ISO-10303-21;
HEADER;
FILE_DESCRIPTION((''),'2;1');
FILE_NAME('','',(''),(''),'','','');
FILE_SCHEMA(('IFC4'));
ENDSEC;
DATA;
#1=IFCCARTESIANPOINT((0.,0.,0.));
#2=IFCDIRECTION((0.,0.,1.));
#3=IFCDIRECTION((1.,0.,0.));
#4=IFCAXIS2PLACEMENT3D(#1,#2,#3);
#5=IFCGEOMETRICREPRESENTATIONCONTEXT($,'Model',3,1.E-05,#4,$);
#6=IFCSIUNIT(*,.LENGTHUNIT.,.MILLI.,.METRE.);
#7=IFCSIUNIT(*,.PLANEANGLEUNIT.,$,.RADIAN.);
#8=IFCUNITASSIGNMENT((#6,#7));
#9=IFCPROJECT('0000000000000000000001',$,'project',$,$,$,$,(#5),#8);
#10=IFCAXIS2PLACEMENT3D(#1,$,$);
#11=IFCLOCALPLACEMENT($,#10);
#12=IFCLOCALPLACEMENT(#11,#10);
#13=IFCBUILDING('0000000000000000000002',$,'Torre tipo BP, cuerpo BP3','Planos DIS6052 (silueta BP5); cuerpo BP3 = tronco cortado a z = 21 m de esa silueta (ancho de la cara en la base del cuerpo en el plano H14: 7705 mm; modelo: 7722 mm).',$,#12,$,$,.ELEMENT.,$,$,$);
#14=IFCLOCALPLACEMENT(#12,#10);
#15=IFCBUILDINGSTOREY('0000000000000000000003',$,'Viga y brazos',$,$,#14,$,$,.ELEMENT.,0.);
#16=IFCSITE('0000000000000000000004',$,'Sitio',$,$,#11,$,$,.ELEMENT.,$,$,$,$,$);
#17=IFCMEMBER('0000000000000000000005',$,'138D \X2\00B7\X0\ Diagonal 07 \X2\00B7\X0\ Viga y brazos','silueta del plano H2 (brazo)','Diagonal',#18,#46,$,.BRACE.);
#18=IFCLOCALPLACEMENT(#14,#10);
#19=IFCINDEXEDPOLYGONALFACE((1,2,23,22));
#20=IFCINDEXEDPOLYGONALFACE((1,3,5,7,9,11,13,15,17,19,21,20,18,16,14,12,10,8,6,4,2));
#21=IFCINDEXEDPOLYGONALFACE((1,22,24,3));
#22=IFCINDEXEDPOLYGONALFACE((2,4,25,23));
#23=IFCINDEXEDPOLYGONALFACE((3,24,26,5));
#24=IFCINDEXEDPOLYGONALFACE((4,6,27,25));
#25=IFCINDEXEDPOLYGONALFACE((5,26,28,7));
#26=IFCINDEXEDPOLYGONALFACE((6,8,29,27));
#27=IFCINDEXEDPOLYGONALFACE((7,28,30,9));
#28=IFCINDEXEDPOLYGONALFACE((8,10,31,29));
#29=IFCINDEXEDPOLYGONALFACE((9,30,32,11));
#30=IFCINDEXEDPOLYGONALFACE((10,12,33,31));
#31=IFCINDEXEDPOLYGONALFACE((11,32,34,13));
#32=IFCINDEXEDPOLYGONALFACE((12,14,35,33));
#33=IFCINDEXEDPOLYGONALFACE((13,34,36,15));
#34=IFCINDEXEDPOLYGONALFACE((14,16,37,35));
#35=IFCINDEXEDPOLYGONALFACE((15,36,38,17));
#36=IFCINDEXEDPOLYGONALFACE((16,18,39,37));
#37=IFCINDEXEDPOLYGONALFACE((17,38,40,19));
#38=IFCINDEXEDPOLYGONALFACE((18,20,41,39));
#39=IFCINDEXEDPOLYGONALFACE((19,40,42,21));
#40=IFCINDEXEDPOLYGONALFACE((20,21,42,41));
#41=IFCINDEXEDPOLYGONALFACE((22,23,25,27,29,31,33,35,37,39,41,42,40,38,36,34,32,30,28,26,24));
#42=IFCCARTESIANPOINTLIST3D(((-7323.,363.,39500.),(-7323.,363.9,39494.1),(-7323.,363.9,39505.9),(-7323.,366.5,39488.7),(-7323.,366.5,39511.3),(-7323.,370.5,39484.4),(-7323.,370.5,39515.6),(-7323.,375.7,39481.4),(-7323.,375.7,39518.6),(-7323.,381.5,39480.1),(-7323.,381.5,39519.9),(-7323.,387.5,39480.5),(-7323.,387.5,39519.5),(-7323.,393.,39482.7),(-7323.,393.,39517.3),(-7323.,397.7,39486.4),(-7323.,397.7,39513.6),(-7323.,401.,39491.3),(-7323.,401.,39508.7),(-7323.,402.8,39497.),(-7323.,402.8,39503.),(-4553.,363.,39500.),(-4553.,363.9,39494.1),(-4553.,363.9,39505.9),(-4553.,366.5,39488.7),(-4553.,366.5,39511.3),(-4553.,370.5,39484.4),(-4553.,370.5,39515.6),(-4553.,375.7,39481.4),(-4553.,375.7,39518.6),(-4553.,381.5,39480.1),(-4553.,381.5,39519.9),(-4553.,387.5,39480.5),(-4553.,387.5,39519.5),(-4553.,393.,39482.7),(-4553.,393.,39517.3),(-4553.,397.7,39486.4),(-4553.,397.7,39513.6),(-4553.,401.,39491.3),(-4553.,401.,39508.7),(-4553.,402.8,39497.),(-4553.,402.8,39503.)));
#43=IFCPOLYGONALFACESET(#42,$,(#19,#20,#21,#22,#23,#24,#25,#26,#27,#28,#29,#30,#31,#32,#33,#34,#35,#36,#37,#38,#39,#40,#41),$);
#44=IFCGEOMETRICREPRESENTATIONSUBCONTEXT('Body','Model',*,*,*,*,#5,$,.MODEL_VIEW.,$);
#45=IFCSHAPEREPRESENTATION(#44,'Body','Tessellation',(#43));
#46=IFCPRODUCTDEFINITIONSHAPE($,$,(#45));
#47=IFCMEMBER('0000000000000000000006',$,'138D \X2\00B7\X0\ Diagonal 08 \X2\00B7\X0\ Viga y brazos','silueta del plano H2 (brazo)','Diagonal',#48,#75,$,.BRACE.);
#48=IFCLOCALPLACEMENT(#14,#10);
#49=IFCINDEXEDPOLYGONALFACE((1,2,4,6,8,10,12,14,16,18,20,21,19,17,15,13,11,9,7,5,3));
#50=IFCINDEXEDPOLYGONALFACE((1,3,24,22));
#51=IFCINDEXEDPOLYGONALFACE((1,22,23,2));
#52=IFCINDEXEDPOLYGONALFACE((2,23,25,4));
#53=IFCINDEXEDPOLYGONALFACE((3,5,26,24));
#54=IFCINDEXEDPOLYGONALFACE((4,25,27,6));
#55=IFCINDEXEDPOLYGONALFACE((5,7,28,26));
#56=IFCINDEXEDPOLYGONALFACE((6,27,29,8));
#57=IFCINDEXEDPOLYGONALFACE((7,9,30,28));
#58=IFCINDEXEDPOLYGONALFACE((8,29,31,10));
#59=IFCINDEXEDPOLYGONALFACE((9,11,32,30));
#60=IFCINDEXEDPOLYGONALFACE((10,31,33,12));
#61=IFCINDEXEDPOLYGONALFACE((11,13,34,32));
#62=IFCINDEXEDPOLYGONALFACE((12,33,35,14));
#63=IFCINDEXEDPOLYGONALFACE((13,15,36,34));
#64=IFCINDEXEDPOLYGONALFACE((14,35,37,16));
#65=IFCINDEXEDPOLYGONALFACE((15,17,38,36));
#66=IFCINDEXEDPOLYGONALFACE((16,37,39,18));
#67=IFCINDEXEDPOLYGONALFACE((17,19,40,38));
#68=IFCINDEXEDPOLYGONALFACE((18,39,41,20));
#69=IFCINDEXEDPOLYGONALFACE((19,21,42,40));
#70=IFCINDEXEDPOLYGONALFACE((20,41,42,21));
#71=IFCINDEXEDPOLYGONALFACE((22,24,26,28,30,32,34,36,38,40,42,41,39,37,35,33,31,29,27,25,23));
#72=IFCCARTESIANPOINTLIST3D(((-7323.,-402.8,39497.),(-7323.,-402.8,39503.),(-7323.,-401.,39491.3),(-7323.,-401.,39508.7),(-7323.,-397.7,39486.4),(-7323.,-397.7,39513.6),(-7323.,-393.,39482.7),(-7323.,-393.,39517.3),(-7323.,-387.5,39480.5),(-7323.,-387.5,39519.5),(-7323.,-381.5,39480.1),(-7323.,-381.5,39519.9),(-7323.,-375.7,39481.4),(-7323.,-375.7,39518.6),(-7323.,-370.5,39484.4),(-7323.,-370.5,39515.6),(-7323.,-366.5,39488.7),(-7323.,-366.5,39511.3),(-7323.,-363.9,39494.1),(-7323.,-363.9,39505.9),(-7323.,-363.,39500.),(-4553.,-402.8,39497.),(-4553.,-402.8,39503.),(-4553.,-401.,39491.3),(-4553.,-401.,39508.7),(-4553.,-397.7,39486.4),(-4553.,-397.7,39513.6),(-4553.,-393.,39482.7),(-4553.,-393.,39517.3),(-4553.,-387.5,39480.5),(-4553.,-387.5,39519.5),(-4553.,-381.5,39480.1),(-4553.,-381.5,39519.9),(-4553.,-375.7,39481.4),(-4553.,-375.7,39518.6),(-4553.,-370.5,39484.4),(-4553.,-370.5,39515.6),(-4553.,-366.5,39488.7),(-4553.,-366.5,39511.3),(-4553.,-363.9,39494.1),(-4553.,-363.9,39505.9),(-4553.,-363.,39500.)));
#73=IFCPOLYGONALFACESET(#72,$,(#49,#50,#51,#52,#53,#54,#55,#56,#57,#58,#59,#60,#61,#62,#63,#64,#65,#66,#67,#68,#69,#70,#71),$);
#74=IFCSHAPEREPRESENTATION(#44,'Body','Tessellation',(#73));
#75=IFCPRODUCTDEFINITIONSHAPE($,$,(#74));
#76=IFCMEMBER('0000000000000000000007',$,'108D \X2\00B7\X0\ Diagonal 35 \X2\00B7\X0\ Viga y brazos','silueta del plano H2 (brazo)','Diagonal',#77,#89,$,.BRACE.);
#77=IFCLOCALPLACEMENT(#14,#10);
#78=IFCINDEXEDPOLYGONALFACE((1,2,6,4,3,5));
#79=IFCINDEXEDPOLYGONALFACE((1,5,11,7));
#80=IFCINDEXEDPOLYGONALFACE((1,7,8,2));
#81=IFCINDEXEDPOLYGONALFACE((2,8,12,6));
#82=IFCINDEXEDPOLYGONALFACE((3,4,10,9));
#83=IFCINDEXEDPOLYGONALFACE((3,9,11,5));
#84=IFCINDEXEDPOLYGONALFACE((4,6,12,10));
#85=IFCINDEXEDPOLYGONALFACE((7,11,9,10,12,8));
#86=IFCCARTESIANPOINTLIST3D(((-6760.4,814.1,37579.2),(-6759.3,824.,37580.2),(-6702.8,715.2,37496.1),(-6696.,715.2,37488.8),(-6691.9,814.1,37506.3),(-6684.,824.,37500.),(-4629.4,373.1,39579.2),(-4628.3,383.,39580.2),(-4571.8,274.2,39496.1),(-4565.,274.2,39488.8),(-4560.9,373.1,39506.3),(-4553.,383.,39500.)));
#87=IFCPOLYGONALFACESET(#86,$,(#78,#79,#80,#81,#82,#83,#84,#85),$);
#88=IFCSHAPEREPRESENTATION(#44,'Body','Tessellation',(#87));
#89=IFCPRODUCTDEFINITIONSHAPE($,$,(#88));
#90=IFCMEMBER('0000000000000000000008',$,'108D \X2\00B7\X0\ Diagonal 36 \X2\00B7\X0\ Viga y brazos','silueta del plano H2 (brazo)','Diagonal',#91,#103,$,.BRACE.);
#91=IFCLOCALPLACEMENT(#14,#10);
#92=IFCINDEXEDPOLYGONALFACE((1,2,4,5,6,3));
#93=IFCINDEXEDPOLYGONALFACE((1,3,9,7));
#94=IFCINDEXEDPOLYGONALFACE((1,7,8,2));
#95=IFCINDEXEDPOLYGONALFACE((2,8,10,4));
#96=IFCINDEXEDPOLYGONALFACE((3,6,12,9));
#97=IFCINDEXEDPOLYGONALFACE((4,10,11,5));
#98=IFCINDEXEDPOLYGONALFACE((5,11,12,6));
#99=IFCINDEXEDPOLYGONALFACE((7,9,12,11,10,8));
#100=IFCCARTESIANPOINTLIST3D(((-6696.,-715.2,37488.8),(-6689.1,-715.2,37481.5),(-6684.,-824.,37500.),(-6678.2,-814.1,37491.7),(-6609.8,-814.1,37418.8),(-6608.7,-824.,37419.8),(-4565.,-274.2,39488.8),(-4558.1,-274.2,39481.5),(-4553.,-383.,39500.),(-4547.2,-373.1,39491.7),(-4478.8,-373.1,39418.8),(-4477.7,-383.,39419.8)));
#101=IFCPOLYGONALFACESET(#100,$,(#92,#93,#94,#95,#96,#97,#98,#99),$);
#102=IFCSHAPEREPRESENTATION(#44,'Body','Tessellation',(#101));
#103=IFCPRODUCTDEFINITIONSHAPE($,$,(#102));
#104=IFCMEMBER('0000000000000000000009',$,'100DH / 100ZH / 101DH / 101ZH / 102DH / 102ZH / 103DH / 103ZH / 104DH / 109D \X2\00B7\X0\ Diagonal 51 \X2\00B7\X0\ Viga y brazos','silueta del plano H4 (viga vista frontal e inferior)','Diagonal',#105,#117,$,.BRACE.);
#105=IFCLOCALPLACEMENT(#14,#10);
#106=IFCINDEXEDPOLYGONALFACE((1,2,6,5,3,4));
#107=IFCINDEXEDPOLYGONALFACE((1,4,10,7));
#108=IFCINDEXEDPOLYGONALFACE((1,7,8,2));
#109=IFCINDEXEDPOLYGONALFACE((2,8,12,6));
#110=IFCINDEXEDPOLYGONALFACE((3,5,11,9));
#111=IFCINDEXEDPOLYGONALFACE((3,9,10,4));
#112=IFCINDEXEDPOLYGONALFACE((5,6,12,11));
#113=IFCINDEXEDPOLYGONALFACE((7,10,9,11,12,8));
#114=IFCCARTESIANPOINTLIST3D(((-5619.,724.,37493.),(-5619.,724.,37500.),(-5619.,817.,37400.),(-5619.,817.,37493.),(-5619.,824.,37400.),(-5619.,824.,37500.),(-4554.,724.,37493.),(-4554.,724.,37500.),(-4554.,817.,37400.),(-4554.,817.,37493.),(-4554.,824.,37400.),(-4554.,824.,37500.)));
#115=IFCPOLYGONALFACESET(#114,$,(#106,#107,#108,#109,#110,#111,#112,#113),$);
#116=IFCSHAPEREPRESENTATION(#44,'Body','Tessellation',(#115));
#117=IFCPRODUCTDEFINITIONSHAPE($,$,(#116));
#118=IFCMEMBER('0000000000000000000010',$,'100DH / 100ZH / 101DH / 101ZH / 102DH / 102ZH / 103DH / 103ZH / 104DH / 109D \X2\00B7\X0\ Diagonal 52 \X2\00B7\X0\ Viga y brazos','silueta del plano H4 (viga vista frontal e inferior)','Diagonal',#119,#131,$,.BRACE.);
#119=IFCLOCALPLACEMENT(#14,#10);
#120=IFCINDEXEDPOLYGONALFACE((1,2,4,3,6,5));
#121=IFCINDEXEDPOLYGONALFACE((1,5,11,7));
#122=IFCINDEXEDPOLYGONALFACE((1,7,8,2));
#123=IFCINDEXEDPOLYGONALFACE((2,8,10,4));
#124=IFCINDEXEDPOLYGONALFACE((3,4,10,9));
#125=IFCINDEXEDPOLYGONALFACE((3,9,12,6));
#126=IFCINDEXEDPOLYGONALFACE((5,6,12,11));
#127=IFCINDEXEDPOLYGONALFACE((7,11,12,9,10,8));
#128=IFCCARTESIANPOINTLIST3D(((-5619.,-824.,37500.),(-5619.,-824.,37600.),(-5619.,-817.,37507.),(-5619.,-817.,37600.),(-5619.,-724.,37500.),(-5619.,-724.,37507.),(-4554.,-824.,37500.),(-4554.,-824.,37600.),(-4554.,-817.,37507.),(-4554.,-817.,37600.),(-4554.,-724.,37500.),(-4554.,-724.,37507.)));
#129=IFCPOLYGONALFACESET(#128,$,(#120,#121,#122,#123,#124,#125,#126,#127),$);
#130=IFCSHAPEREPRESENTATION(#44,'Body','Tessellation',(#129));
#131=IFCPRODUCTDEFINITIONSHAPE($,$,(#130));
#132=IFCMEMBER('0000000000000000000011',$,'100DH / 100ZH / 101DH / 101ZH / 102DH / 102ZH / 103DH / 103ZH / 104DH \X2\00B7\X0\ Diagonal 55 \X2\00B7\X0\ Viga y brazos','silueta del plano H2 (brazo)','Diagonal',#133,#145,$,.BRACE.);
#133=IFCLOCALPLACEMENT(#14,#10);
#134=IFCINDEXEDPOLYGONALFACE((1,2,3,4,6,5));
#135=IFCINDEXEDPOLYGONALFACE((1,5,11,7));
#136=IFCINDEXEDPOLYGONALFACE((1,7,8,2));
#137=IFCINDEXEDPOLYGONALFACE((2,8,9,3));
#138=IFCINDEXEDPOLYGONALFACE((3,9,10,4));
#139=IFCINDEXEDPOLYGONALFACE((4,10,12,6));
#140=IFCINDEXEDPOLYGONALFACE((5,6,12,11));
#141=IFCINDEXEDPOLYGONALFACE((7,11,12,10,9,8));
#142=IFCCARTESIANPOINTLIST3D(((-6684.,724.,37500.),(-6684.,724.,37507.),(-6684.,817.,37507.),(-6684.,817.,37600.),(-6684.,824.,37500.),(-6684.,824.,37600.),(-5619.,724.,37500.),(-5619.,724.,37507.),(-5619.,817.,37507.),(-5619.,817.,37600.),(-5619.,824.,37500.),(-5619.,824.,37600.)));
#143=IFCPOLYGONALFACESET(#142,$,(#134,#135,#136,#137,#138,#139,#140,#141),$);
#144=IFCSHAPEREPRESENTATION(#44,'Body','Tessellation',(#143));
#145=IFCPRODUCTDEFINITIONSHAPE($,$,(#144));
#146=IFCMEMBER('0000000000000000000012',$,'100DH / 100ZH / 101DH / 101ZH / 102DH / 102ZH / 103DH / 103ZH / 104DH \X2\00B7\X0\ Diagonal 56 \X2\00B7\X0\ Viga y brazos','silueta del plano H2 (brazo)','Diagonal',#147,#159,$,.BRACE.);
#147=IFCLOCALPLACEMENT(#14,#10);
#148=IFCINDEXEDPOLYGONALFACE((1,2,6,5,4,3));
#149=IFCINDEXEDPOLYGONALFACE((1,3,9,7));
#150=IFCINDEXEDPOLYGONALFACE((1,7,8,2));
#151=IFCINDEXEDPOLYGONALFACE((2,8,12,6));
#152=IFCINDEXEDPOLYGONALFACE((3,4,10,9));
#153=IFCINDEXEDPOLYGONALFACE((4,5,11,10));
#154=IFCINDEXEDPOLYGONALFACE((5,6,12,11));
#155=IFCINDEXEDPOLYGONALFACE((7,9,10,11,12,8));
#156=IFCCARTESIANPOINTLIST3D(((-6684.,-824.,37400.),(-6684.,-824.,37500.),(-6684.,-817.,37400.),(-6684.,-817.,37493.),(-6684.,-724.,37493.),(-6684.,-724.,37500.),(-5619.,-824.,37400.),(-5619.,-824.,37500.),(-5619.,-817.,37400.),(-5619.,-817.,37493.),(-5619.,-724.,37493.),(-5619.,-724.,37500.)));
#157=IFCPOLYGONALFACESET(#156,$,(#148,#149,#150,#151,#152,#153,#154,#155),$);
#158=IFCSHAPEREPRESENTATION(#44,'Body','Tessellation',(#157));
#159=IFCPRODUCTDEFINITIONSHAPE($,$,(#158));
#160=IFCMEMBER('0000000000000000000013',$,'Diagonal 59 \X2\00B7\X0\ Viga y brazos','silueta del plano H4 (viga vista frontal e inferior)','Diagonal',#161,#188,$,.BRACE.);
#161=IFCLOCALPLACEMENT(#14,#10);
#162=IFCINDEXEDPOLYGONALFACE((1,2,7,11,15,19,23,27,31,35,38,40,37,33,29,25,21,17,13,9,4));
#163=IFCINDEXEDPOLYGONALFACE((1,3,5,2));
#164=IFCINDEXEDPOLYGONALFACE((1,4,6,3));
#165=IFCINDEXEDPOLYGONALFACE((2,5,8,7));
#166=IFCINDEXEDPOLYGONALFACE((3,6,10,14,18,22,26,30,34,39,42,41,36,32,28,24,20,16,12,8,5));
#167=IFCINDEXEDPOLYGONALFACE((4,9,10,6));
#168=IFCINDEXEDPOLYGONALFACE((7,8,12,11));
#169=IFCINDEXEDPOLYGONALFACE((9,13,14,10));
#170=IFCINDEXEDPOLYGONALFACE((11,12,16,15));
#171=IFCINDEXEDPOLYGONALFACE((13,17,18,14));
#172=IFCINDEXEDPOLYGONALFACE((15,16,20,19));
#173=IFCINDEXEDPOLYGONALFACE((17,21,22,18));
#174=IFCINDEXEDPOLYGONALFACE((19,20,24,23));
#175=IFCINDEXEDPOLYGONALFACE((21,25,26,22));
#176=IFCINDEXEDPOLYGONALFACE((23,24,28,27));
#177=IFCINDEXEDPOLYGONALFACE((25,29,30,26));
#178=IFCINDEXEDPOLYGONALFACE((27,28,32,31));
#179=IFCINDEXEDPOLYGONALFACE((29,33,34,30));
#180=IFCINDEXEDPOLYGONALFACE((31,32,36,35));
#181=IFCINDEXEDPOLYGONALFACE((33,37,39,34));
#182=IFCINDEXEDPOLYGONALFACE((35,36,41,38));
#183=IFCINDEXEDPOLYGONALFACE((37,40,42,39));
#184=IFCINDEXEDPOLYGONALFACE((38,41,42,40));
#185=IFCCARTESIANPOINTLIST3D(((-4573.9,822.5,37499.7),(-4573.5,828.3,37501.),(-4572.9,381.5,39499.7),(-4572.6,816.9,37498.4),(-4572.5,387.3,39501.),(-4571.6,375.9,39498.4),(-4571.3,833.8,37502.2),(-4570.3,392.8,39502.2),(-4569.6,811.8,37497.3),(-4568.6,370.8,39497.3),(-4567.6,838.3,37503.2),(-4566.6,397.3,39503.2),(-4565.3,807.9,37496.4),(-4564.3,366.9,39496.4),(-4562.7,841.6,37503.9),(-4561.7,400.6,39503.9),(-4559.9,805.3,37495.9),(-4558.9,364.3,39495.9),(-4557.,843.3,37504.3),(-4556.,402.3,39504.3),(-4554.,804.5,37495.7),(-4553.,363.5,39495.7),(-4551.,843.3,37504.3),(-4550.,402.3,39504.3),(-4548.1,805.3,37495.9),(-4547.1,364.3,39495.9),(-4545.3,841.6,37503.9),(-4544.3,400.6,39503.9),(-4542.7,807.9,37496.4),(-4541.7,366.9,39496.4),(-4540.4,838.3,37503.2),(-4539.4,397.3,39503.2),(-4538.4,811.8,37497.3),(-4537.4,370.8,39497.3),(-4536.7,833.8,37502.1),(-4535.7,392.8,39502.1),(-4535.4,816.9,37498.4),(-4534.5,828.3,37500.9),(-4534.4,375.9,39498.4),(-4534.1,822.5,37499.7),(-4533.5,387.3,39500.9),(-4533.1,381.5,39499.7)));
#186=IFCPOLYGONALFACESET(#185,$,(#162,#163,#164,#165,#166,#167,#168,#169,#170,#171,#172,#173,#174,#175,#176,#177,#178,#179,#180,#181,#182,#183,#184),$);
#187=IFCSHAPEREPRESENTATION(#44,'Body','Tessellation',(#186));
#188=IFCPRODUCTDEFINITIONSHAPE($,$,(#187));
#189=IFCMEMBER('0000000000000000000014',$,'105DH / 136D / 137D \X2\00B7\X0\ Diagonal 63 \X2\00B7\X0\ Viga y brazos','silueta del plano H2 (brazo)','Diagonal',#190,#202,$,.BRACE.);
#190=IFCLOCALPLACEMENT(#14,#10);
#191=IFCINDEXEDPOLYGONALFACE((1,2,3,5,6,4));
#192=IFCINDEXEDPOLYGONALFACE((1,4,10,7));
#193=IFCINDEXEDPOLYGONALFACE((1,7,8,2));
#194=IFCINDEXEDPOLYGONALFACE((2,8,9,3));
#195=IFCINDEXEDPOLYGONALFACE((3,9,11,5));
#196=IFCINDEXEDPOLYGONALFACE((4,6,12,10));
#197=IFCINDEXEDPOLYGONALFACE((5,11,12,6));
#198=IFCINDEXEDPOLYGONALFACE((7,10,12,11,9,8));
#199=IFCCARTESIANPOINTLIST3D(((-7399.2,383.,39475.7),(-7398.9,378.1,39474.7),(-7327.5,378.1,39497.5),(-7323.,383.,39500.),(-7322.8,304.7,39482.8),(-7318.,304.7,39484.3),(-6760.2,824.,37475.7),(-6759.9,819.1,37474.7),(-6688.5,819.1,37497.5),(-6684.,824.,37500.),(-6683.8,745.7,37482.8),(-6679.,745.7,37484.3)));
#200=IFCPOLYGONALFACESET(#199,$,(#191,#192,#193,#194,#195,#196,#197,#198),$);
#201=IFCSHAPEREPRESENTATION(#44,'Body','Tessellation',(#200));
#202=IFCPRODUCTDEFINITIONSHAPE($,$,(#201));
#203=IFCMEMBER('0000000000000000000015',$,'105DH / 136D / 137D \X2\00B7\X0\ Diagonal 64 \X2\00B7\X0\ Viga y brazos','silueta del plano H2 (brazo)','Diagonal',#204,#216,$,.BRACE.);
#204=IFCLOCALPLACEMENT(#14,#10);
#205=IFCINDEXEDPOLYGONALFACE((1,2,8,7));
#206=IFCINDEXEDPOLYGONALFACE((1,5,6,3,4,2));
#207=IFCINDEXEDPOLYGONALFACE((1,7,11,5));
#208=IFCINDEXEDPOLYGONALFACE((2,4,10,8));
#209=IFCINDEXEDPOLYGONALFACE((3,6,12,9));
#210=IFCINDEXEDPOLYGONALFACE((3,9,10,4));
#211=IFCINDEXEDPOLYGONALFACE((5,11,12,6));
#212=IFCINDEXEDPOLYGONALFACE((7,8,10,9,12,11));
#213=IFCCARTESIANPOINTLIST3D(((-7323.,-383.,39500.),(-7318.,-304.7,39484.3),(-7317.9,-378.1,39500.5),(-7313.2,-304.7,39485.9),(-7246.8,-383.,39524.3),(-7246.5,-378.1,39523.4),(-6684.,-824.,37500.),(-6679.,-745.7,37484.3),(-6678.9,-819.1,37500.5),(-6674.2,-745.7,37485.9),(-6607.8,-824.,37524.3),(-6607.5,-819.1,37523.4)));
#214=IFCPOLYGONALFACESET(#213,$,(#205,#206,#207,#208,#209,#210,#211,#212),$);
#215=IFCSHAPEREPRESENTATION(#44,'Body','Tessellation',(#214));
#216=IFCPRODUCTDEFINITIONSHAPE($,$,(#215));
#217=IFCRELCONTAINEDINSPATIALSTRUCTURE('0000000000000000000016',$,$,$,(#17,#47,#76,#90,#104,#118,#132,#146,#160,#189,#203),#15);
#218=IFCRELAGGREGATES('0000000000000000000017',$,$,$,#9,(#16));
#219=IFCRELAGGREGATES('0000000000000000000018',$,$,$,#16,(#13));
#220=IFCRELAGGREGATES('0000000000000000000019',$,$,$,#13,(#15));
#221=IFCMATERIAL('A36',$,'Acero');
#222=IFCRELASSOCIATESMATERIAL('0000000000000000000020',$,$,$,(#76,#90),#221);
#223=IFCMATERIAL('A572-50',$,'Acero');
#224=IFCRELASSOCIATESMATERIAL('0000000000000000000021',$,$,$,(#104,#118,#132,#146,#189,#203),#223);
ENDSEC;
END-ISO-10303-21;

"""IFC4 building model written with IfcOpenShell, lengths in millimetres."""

from ifc_helpers import new_model, si_unit, frame, frame_2d, origin, origin_with_axes, place, context, subcontext, project, spatial, circle, l_section, extrude, material, element, save


model = new_model("IFC4")

# Units and contexts
model_context = context("Model", 3, precision=1e-05, world=origin_with_axes())
body_context = subcontext(model_context, "Body", "Model", "MODEL_VIEW")
ifc_project = project(units=[si_unit("LENGTHUNIT", "METRE", prefix="MILLI"), si_unit("PLANEANGLEUNIT", "RADIAN")], contexts=[model_context])

# Site, building, storey
site_placement = place(None, origin())
site = spatial("IfcSite", under=ifc_project, at=site_placement, Name="Sitio", CompositionType="ELEMENT")
building_placement = place(site_placement, origin())
building = spatial("IfcBuilding", under=site, at=building_placement, Name="Torre tipo BP, cuerpo BP3", Description="Planos DIS6052 (silueta BP5); cuerpo BP3 = tronco cortado a z = 21 m de esa silueta (ancho de la cara en la base del cuerpo en el plano H14: 7705 mm; modelo: 7722 mm).", CompositionType="ELEMENT")
storey_placement = place(building_placement, origin())
storey = spatial("IfcBuildingStorey", under=building, at=storey_placement, Name="Viga y brazos", CompositionType="ELEMENT", Elevation=0.0)

# Members
for number, where, z_axis, x_axis, name in (
    (1, (-7323.0, 383.0, 39500.0), (1.0, 0.0, 0.0), (0.0, -1.0, 0.0), "138D · Diagonal 07 · Viga y brazos"),
    (2, (-7323.0, -383.0, 39500.0), (1.0, 0.0, 0.0), (0.0, 1.0, 0.0), "138D · Diagonal 08 · Viga y brazos"),
):
    element("IfcMember", number, at=place(storey_placement, frame(where, z_axis=z_axis, x_axis=x_axis)), inside=storey, Name=name, Description="silueta del plano H2 (brazo)", ObjectType="Diagonal", PredefinedType="BRACE", context=body_context, shape_type="SweptSolid", body=[
        extrude(circle(Radius=20.0), None, (0.0, 0.0, 1.0), 2770.0),
    ])
ifc_material_1 = material(Name="A36", Category="Acero")
for number, where, z_axis, x_axis, name in (
    (3, (-4553.0, 383.0, 39500.0), (-0.721001, 0.149208, -0.676679), (-0.108797, -0.988806, -0.102109), "108D · Diagonal 35 · Viga y brazos"),
    (4, (-4553.0, -383.0, 39500.0), (-0.721001, -0.149208, -0.676679), (-0.108797, 0.988806, -0.102109), "108D · Diagonal 36 · Viga y brazos"),
):
    element("IfcMember", number, at=place(storey_placement, frame(where, z_axis=z_axis, x_axis=x_axis)), inside=storey, material=ifc_material_1, Name=name, Description="silueta del plano H2 (brazo)", ObjectType="Diagonal", PredefinedType="BRACE", context=body_context, shape_type="SweptSolid", body=[
        extrude(l_section(Depth=110.0, Width=110.0, Thickness=10.0, at=frame_2d((55.0, 55.0))), None, (0.0, 0.0, 1.0), 2955.6),
    ])
ifc_material_2 = material(Name="A572-50", Category="Acero")
for number, where, z_axis, x_axis, name, description in (
    (5, (-5619.0, 824.0, 37500.0), (1.0, 0.0, 0.0), (0.0, -1.0, 0.0), "100DH / 100ZH / 101DH / 101ZH / 102DH / 102ZH / 103DH / 103ZH / 104DH / 109D · Diagonal 51 · Viga y brazos", "silueta del plano H4 (viga vista frontal e inferior)"),
    (6, (-5619.0, -824.0, 37500.0), (1.0, 0.0, 0.0), (0.0, 1.0, 0.0), "100DH / 100ZH / 101DH / 101ZH / 102DH / 102ZH / 103DH / 103ZH / 104DH / 109D · Diagonal 52 · Viga y brazos", "silueta del plano H4 (viga vista frontal e inferior)"),
    (7, (-5619.0, 824.0, 37500.0), (-1.0, 0.0, 0.0), (0.0, -1.0, 0.0), "100DH / 100ZH / 101DH / 101ZH / 102DH / 102ZH / 103DH / 103ZH / 104DH · Diagonal 55 · Viga y brazos", "silueta del plano H2 (brazo)"),
    (8, (-5619.0, -824.0, 37500.0), (-1.0, 0.0, 0.0), (0.0, 1.0, 0.0), "100DH / 100ZH / 101DH / 101ZH / 102DH / 102ZH / 103DH / 103ZH / 104DH · Diagonal 56 · Viga y brazos", "silueta del plano H2 (brazo)"),
):
    element("IfcMember", number, at=place(storey_placement, frame(where, z_axis=z_axis, x_axis=x_axis)), inside=storey, material=ifc_material_2, Name=name, Description=description, ObjectType="Diagonal", PredefinedType="BRACE", context=body_context, shape_type="SweptSolid", body=[
        extrude(l_section(Depth=100.0, Width=100.0, Thickness=7.0, at=frame_2d((50.0, 50.0))), None, (0.0, 0.0, 1.0), 1065.0),
    ])
member_placement = place(storey_placement, frame((-4553.0, 383.0, 39500.0), z_axis=(-0.000488, 0.215327, -0.976542), x_axis=(-0.000108, -0.976542, -0.215327)))
element("IfcMember", 9, at=member_placement, inside=storey, Name="Diagonal 59 · Viga y brazos", Description="silueta del plano H4 (viga vista frontal e inferior)", ObjectType="Diagonal", PredefinedType="BRACE", context=body_context, shape_type="SweptSolid", body=[
    extrude(circle(Radius=20.0), None, (0.0, 0.0, 1.0), 2048.0),
])
for number, where, z_axis, x_axis, name in (
    (10, (-7323.0, 383.0, 39500.0), (0.297845, 0.205555, -0.932221), (0.062559, -0.978646, -0.195804), "105DH / 136D / 137D · Diagonal 63 · Viga y brazos"),
    (11, (-7323.0, -383.0, 39500.0), (0.297845, -0.205555, -0.932221), (0.062559, 0.978646, -0.195804), "105DH / 136D / 137D · Diagonal 64 · Viga y brazos"),
):
    element("IfcMember", number, at=place(storey_placement, frame(where, z_axis=z_axis, x_axis=x_axis)), inside=storey, material=ifc_material_2, Name=name, Description="silueta del plano H2 (brazo)", ObjectType="Diagonal", PredefinedType="BRACE", context=body_context, shape_type="SweptSolid", body=[
        extrude(l_section(Depth=80.0, Width=80.0, Thickness=5.0, at=frame_2d((40.0, 40.0))), None, (0.0, 0.0, 1.0), 2145.4),
    ])

save(model, "model.ifc")
